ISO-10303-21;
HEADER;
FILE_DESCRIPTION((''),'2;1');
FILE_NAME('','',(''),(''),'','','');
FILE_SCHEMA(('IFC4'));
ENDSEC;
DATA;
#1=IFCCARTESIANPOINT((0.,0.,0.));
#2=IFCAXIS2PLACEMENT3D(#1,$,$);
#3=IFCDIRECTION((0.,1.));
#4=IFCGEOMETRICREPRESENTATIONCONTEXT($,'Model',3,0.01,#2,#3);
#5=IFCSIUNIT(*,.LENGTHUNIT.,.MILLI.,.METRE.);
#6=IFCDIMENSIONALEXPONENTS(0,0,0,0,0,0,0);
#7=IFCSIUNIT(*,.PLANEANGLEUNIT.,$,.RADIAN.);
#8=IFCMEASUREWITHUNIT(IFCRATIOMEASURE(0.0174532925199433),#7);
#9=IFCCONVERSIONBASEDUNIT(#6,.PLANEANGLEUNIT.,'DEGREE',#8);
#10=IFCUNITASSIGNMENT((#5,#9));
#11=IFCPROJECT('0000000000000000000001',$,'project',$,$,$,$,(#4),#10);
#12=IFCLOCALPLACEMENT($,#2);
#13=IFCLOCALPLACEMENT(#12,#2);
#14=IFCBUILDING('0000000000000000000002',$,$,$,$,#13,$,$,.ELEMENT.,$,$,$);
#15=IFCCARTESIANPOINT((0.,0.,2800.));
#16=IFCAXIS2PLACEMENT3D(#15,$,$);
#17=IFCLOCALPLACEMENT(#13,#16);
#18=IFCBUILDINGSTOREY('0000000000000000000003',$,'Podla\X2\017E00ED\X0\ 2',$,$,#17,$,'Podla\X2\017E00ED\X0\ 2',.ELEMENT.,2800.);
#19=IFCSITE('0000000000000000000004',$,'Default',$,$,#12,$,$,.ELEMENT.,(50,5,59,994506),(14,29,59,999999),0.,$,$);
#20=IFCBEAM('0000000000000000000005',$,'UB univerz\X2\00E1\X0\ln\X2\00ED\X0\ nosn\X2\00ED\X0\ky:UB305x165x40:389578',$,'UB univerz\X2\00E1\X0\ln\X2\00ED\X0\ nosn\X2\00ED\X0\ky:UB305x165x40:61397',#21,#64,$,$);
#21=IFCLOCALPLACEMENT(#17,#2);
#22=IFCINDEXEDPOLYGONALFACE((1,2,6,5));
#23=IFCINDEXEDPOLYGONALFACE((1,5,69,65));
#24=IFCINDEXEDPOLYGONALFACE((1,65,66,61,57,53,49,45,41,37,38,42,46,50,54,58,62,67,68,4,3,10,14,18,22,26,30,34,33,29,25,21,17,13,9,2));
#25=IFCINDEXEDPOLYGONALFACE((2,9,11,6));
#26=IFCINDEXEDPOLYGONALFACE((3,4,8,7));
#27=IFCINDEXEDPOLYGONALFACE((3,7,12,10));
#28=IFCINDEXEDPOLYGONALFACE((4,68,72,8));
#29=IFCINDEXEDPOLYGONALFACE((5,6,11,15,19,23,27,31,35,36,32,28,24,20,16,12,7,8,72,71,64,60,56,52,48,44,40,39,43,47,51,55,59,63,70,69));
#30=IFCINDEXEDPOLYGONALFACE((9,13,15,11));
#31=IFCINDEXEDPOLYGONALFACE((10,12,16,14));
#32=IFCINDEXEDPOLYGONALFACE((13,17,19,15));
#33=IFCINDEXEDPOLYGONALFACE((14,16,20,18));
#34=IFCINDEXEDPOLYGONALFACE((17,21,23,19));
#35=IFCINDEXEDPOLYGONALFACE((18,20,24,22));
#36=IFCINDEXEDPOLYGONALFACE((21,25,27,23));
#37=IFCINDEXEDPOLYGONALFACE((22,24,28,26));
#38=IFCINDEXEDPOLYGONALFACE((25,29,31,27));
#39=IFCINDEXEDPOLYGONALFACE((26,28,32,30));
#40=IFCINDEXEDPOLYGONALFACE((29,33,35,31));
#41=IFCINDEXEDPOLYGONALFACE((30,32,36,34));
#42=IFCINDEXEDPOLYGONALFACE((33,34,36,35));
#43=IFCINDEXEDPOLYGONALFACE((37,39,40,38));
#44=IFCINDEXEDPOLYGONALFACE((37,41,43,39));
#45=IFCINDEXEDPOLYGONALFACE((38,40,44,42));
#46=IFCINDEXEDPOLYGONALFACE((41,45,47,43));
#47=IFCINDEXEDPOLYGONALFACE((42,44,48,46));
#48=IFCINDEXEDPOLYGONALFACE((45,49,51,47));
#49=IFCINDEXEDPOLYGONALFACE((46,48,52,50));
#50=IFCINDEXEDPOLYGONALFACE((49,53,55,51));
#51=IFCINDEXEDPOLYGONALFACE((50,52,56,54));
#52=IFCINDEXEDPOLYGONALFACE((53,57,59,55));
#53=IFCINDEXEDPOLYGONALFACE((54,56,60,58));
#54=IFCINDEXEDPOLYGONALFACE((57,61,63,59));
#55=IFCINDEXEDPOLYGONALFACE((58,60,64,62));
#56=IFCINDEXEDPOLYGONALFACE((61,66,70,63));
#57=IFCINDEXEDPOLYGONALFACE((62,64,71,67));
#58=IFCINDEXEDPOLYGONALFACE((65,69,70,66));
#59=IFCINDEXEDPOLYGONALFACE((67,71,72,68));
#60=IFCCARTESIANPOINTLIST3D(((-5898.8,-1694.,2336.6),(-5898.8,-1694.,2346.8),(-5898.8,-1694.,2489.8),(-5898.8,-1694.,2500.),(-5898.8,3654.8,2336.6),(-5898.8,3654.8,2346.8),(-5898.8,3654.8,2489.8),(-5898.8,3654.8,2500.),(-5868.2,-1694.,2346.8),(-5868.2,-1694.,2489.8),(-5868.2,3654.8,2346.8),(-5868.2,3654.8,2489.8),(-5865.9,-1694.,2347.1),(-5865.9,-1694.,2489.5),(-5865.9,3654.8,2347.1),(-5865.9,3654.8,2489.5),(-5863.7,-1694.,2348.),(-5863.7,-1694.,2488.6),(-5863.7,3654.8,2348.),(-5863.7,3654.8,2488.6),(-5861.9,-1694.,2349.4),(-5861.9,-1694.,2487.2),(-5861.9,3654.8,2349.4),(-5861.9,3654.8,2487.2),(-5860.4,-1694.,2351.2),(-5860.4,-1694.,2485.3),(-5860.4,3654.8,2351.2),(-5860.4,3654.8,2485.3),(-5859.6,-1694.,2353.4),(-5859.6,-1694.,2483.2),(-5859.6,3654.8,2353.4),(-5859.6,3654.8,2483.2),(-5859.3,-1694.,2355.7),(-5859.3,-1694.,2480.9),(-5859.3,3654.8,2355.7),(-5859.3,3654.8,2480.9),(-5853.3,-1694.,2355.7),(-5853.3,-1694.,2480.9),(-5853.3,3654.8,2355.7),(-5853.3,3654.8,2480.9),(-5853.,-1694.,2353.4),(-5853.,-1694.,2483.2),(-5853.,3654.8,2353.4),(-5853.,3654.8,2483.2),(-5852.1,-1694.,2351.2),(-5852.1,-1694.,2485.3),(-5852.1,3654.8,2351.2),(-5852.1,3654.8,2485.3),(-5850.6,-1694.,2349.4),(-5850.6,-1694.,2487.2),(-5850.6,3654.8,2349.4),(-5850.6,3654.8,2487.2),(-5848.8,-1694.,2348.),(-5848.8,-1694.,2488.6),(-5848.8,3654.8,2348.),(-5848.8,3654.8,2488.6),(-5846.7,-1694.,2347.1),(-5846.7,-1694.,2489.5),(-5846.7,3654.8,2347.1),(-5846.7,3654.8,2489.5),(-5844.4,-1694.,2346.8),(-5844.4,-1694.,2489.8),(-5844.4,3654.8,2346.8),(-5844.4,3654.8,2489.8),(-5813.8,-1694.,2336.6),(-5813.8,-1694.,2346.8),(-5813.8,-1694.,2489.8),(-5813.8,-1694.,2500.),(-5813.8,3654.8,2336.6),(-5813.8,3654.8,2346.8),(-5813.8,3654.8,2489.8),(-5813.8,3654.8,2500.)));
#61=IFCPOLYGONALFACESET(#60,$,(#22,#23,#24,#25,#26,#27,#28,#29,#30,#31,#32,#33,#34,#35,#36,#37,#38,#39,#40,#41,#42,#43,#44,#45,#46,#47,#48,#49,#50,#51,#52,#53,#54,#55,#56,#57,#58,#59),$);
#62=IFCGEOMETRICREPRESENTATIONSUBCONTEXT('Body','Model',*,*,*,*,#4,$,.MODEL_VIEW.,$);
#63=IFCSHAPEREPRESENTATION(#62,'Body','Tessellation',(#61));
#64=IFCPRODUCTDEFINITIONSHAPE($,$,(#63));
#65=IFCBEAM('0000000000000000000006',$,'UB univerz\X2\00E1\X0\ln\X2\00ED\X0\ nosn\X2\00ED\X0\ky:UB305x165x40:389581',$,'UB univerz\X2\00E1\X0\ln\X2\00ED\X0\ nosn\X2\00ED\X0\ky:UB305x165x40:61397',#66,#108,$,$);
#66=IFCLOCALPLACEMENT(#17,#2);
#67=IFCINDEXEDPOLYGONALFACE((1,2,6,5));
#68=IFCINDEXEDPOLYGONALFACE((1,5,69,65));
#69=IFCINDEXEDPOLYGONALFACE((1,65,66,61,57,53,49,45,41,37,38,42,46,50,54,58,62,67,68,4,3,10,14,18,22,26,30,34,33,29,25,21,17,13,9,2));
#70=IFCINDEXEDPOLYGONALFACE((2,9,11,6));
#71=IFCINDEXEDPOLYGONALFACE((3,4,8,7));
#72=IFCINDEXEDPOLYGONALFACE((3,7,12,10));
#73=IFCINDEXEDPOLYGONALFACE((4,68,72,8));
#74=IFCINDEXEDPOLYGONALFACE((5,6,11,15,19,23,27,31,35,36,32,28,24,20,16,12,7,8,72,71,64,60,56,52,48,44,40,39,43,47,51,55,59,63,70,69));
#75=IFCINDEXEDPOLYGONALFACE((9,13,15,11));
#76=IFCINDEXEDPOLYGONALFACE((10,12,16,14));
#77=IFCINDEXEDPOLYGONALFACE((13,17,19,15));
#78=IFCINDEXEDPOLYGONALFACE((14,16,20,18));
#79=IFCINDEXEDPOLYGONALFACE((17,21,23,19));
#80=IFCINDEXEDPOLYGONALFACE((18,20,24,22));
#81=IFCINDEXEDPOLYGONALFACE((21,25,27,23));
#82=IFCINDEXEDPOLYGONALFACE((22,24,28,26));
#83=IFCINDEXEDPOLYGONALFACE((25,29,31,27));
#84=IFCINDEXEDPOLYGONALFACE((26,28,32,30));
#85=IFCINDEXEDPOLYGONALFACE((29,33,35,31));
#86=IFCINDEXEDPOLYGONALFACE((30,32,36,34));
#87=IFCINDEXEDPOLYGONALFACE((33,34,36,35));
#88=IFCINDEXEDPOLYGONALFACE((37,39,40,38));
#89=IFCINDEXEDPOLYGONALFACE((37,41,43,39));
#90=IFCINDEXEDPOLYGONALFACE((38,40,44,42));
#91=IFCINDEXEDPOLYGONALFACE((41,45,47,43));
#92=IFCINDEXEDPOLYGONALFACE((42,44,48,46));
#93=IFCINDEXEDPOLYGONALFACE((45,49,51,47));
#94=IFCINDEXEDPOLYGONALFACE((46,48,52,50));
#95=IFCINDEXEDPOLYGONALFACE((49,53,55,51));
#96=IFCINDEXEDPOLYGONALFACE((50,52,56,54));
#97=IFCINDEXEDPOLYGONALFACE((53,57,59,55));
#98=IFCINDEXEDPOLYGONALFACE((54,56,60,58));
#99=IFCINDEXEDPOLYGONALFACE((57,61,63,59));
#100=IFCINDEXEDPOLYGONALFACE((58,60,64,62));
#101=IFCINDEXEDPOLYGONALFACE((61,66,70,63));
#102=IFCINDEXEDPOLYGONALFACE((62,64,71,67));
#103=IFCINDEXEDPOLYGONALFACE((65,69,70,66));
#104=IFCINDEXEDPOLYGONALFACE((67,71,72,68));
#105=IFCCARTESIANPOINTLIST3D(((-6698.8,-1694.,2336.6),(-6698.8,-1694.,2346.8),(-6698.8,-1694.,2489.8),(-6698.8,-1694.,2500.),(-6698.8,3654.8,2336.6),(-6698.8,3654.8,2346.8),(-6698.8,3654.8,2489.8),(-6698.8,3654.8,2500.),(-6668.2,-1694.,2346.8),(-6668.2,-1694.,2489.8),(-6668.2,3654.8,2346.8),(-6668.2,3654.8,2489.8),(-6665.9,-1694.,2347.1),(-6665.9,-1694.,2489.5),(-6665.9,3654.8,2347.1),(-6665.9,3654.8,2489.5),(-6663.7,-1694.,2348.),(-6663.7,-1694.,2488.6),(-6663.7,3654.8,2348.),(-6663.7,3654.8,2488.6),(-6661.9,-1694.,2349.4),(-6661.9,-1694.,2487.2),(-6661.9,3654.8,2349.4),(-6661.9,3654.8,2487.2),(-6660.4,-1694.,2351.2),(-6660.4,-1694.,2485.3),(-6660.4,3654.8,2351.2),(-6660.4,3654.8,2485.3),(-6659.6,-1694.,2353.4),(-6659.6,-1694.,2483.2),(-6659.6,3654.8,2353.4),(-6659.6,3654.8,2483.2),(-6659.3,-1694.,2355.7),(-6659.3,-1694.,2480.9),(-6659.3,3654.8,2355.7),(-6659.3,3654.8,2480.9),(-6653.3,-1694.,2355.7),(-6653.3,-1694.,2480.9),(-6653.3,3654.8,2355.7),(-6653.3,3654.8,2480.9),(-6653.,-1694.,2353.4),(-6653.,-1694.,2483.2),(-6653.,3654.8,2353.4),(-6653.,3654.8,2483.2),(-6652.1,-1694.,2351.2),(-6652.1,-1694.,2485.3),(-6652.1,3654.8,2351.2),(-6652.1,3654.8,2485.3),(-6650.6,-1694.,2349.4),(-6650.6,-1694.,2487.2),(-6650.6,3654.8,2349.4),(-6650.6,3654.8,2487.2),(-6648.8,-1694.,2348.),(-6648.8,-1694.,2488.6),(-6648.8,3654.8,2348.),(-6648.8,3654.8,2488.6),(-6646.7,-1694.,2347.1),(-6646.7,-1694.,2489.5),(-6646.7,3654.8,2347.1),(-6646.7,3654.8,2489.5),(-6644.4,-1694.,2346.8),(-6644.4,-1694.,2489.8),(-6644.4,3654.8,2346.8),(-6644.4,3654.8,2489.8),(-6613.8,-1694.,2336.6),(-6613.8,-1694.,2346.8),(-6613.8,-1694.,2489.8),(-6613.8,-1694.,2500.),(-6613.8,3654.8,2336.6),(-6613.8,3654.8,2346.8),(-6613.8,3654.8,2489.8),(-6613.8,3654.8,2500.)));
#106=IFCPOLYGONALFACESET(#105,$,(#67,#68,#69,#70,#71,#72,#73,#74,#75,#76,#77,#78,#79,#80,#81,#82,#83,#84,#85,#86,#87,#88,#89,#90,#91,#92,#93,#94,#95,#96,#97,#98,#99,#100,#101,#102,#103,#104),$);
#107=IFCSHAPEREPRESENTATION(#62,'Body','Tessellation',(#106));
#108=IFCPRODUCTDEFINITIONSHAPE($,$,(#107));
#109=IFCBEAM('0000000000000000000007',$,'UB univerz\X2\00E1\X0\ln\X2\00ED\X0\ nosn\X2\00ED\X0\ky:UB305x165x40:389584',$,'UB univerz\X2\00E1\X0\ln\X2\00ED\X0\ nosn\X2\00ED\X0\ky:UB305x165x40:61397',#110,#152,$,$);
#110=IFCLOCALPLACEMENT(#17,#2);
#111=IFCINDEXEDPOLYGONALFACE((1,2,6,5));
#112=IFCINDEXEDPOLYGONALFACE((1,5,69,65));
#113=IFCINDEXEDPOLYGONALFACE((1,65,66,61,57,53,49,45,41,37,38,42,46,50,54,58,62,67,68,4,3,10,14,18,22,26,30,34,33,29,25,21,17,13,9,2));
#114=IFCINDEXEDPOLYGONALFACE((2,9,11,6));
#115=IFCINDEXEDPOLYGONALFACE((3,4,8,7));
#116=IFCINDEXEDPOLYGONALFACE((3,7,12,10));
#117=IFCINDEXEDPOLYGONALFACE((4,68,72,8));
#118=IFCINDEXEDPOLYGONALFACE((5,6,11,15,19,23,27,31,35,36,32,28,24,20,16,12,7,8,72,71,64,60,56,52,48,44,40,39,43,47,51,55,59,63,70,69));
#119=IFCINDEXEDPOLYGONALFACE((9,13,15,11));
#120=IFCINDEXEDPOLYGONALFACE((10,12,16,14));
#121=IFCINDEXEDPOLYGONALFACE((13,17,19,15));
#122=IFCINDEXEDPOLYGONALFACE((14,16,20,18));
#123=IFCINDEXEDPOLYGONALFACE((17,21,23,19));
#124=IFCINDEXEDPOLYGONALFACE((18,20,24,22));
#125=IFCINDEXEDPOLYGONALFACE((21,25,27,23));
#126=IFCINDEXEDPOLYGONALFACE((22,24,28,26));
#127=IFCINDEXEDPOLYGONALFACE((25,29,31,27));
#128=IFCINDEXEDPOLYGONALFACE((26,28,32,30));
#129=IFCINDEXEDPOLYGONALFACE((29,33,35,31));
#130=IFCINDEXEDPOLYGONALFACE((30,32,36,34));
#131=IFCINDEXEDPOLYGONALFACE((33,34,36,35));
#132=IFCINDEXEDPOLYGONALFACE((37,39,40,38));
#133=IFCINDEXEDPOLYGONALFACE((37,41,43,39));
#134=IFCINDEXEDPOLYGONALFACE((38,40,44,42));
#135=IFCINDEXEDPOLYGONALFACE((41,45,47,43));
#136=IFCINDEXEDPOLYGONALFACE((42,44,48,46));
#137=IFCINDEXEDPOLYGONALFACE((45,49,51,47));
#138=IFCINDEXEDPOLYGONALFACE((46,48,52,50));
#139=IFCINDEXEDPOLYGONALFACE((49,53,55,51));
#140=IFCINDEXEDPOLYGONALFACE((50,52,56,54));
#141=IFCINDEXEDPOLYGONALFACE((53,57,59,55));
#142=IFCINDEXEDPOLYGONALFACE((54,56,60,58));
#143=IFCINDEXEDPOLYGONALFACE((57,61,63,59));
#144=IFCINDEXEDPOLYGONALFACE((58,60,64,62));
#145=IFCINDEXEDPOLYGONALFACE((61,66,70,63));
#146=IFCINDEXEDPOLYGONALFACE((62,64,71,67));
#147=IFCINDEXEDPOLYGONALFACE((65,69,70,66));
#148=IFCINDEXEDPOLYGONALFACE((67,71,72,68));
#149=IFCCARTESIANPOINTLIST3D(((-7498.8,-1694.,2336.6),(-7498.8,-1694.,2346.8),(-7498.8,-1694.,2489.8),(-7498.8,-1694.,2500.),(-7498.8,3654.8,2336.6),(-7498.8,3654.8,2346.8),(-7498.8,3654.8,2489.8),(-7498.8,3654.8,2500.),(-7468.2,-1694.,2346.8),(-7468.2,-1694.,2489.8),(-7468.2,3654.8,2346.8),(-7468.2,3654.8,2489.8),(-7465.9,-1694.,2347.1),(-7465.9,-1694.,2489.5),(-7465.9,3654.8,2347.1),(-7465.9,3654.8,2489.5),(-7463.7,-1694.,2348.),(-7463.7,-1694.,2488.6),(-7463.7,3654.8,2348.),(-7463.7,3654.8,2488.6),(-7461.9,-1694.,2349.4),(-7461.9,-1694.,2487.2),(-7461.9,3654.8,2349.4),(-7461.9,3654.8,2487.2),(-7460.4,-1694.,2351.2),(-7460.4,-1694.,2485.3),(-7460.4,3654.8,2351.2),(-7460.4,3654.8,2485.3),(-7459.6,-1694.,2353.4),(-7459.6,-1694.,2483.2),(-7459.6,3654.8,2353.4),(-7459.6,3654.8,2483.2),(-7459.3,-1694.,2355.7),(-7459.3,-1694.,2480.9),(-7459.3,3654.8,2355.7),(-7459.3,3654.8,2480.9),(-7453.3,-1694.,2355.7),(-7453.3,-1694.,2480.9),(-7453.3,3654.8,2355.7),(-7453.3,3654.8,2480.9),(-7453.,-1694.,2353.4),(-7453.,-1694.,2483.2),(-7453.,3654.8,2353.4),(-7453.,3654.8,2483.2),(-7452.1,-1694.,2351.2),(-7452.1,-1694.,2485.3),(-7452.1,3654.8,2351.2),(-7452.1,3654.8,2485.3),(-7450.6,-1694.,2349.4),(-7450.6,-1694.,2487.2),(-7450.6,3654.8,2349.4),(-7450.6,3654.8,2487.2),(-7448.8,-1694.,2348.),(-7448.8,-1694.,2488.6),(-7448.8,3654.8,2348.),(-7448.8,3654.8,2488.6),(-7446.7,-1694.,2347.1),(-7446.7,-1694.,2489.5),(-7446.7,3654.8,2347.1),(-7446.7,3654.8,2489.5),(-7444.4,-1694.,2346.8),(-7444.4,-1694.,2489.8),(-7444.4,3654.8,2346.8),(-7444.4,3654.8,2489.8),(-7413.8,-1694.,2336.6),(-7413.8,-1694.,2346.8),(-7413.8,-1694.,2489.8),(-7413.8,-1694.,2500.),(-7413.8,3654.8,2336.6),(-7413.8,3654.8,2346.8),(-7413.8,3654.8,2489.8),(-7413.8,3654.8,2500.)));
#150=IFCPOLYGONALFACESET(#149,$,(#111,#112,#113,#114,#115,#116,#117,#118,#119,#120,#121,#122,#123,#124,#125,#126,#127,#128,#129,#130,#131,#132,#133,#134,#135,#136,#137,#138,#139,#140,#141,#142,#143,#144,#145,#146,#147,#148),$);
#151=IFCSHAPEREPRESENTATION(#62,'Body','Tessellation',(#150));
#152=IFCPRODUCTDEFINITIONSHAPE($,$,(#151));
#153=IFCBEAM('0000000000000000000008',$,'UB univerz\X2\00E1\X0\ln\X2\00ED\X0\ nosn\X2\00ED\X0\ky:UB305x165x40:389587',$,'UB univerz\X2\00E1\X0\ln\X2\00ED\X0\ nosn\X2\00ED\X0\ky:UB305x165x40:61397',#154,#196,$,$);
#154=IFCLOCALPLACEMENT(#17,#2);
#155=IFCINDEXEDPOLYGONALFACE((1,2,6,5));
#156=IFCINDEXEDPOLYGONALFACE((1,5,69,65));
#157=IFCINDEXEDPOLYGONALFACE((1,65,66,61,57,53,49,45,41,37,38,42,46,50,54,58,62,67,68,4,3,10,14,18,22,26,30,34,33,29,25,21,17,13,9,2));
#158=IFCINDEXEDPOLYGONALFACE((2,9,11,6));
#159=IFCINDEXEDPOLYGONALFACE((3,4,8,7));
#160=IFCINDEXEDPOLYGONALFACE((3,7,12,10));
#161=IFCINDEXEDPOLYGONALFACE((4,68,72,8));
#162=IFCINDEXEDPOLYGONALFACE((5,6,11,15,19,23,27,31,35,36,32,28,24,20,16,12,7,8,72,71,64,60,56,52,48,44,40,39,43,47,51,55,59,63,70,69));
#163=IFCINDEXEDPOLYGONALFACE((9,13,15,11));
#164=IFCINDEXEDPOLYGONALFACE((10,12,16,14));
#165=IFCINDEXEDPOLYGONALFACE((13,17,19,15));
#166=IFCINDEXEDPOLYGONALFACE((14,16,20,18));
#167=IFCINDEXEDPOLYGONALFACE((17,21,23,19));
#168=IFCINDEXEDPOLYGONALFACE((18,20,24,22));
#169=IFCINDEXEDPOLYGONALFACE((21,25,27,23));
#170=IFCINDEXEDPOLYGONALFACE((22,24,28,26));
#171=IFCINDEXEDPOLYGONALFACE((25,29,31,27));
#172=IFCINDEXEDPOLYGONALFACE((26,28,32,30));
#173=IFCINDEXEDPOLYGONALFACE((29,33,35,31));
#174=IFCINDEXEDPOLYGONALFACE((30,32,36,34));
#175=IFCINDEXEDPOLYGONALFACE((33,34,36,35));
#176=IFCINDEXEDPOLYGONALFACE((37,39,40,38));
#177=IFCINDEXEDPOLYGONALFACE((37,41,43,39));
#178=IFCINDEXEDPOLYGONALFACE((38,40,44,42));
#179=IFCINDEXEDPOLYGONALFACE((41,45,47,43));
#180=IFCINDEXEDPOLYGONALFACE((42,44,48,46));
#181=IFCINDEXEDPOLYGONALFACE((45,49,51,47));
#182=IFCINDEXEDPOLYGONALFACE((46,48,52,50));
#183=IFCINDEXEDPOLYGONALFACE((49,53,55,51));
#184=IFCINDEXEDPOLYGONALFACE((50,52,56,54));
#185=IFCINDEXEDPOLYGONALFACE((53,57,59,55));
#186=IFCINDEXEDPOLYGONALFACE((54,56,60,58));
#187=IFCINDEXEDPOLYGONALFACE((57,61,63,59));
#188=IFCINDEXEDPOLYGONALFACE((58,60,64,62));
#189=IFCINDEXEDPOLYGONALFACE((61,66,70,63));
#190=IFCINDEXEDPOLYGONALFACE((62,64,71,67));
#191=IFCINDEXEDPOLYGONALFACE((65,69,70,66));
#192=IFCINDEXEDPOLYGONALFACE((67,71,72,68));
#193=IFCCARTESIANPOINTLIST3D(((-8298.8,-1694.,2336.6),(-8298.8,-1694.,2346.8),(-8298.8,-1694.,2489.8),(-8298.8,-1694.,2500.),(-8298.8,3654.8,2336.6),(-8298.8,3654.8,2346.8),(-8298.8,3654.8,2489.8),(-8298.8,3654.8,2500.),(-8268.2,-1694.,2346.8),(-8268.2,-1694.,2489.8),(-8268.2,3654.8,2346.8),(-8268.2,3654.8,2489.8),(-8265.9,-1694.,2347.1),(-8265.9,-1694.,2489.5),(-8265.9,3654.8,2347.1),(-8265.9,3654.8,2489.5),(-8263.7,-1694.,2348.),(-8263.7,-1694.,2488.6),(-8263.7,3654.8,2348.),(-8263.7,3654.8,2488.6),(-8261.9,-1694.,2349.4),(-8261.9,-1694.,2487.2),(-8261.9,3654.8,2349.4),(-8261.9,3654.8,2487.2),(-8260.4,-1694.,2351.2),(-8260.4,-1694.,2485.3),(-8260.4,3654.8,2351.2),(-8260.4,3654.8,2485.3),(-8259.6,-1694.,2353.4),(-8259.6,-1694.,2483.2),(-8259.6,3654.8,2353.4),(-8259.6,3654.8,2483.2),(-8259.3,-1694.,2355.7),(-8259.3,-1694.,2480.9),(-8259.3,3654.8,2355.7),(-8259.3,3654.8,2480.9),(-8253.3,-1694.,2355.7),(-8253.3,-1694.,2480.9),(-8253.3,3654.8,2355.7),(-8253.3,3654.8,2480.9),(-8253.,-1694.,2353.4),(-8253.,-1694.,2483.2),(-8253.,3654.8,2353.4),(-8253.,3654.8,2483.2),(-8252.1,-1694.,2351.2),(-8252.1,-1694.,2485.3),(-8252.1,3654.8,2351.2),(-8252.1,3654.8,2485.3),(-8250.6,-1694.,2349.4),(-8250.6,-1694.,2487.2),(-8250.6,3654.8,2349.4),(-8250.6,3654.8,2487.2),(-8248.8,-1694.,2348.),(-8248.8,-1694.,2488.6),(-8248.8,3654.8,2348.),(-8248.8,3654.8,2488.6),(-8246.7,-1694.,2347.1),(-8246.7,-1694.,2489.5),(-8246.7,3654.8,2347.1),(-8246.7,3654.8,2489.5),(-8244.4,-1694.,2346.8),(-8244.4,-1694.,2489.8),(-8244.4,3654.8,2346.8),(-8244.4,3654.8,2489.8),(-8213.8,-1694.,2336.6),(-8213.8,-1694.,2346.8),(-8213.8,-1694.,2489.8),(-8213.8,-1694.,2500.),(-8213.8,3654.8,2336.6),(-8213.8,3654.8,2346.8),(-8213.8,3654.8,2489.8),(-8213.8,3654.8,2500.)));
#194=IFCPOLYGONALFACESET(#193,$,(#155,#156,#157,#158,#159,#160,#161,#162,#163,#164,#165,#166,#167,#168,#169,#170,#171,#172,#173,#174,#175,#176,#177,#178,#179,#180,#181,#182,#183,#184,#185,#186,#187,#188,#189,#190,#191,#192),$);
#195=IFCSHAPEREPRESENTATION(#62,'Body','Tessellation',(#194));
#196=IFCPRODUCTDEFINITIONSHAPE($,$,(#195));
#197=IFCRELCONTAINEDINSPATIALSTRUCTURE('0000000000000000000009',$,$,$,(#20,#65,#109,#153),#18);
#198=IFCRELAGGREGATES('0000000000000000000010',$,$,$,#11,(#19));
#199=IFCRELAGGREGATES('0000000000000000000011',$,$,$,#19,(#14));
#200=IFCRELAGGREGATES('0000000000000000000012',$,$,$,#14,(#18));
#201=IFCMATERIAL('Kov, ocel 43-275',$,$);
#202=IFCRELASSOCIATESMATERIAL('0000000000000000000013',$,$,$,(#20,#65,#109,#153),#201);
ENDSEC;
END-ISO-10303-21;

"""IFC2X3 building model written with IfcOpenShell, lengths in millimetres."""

from ifc_helpers import new_model, entity, si_unit, converted_unit, direction, frame, frame_2d, origin, place, context, subcontext, project, spatial, i_section, extrude, material, element, save


model = new_model("IFC2X3")

# Units and contexts
model_context = context("Model", 3, precision=0.01, world=origin(), true_north=direction((0.0, 1.0)))
body_context = subcontext(model_context, "Body", "Model", "MODEL_VIEW")
ifc_project = project(units=[si_unit("LENGTHUNIT", "METRE", prefix="MILLI"), converted_unit("PLANEANGLEUNIT", "DEGREE", entity("IfcRatioMeasure", 0.0174532925199433), si_unit("PLANEANGLEUNIT", "RADIAN"), dimensions=[0, 0, 0, 0, 0, 0, 0])], contexts=[model_context])

# Site, building, storey
site_placement = place(None, origin())
site = spatial("IfcSite", under=ifc_project, at=site_placement, Name="Default", CompositionType="ELEMENT", RefLatitude=(50, 5, 59, 994506), RefLongitude=(14, 29, 59, 999999), RefElevation=0.0)
building_placement = place(site_placement, origin())
building = spatial("IfcBuilding", under=site, at=building_placement, CompositionType="ELEMENT")
storey_placement = place(building_placement, frame((0.0, 0.0, 2800.0)))
storey = spatial("IfcBuildingStorey", under=building, at=storey_placement, Name="Podlaží 2", LongName="Podlaží 2", CompositionType="ELEMENT", Elevation=2800.0)

# Beams
ifc_material = material(Name="Kov, ocel 43-275")
for number, where, z_axis, x_axis, name in (
    (1, (-5856.3, 3654.8, 0.0), (0.0, 0.0, 1.0), (0.0, -1.0, 0.0), "UB univerzální nosníky:UB305x165x40:389578"),
    (2, (-6656.3, 3654.8, 0.0), (0.0, 0.0, 1.0), (0.0, -1.0, 0.0), "UB univerzální nosníky:UB305x165x40:389581"),
):
    element("IfcBeam", number, at=place(storey_placement, frame(where, z_axis=z_axis, x_axis=x_axis)), inside=storey, material=ifc_material, Name=name, ObjectType="UB univerzální nosníky:UB305x165x40:61397", context=body_context, shape_type="SweptSolid", body=[
        extrude(i_section(OverallWidth=85.0, OverallDepth=163.4, WebThickness=6.0, FlangeThickness=10.2, FilletRadius=8.9, at=frame_2d((0.0, 0.0), x_axis=(0.0, 1.0))), frame((0.0, 0.0, 2418.3), z_axis=(1.0, 0.0, 0.0), x_axis=(0.0, 0.0, -1.0)), (0.0, 0.0, 1.0), 5348.8),
    ])
beam_1_placement = place(storey_placement, frame((-7456.3, 3654.8, 0.0), z_axis=(0.0, 0.0, 1.0), x_axis=(0.0, -1.0, 0.0)))
element("IfcBeam", 3, at=beam_1_placement, inside=storey, material=ifc_material, Name="UB univerzální nosníky:UB305x165x40:389584", ObjectType="UB univerzální nosníky:UB305x165x40:61397", context=body_context, shape_type="SweptSolid", body=[
    extrude(i_section(OverallWidth=85.0, OverallDepth=163.4, WebThickness=6.0, FlangeThickness=10.2, FilletRadius=8.9, at=frame_2d((0.0, 0.0), x_axis=(0.0, 1.0))), frame((0.0, 0.0, 2418.3), z_axis=(1.0, 0.0, 0.0), x_axis=(0.0, 0.0, -1.0)), (0.0, 0.0, 1.0), 5348.8),
])
beam_2_placement = place(storey_placement, frame((-8256.3, 3654.8, 0.0), z_axis=(0.0, 0.0, 1.0), x_axis=(0.0, -1.0, 0.0)))
element("IfcBeam", 4, at=beam_2_placement, inside=storey, material=ifc_material, Name="UB univerzální nosníky:UB305x165x40:389587", ObjectType="UB univerzální nosníky:UB305x165x40:61397", context=body_context, shape_type="SweptSolid", body=[
    extrude(i_section(OverallWidth=85.0, OverallDepth=163.4, WebThickness=6.0, FlangeThickness=10.2, FilletRadius=8.9, at=frame_2d((0.0, 0.0), x_axis=(0.0, 1.0))), frame((0.0, 0.0, 2418.3), z_axis=(1.0, 0.0, 0.0), x_axis=(0.0, 0.0, -1.0)), (0.0, 0.0, 1.0), 5348.8),
])

save(model, "model.ifc")
